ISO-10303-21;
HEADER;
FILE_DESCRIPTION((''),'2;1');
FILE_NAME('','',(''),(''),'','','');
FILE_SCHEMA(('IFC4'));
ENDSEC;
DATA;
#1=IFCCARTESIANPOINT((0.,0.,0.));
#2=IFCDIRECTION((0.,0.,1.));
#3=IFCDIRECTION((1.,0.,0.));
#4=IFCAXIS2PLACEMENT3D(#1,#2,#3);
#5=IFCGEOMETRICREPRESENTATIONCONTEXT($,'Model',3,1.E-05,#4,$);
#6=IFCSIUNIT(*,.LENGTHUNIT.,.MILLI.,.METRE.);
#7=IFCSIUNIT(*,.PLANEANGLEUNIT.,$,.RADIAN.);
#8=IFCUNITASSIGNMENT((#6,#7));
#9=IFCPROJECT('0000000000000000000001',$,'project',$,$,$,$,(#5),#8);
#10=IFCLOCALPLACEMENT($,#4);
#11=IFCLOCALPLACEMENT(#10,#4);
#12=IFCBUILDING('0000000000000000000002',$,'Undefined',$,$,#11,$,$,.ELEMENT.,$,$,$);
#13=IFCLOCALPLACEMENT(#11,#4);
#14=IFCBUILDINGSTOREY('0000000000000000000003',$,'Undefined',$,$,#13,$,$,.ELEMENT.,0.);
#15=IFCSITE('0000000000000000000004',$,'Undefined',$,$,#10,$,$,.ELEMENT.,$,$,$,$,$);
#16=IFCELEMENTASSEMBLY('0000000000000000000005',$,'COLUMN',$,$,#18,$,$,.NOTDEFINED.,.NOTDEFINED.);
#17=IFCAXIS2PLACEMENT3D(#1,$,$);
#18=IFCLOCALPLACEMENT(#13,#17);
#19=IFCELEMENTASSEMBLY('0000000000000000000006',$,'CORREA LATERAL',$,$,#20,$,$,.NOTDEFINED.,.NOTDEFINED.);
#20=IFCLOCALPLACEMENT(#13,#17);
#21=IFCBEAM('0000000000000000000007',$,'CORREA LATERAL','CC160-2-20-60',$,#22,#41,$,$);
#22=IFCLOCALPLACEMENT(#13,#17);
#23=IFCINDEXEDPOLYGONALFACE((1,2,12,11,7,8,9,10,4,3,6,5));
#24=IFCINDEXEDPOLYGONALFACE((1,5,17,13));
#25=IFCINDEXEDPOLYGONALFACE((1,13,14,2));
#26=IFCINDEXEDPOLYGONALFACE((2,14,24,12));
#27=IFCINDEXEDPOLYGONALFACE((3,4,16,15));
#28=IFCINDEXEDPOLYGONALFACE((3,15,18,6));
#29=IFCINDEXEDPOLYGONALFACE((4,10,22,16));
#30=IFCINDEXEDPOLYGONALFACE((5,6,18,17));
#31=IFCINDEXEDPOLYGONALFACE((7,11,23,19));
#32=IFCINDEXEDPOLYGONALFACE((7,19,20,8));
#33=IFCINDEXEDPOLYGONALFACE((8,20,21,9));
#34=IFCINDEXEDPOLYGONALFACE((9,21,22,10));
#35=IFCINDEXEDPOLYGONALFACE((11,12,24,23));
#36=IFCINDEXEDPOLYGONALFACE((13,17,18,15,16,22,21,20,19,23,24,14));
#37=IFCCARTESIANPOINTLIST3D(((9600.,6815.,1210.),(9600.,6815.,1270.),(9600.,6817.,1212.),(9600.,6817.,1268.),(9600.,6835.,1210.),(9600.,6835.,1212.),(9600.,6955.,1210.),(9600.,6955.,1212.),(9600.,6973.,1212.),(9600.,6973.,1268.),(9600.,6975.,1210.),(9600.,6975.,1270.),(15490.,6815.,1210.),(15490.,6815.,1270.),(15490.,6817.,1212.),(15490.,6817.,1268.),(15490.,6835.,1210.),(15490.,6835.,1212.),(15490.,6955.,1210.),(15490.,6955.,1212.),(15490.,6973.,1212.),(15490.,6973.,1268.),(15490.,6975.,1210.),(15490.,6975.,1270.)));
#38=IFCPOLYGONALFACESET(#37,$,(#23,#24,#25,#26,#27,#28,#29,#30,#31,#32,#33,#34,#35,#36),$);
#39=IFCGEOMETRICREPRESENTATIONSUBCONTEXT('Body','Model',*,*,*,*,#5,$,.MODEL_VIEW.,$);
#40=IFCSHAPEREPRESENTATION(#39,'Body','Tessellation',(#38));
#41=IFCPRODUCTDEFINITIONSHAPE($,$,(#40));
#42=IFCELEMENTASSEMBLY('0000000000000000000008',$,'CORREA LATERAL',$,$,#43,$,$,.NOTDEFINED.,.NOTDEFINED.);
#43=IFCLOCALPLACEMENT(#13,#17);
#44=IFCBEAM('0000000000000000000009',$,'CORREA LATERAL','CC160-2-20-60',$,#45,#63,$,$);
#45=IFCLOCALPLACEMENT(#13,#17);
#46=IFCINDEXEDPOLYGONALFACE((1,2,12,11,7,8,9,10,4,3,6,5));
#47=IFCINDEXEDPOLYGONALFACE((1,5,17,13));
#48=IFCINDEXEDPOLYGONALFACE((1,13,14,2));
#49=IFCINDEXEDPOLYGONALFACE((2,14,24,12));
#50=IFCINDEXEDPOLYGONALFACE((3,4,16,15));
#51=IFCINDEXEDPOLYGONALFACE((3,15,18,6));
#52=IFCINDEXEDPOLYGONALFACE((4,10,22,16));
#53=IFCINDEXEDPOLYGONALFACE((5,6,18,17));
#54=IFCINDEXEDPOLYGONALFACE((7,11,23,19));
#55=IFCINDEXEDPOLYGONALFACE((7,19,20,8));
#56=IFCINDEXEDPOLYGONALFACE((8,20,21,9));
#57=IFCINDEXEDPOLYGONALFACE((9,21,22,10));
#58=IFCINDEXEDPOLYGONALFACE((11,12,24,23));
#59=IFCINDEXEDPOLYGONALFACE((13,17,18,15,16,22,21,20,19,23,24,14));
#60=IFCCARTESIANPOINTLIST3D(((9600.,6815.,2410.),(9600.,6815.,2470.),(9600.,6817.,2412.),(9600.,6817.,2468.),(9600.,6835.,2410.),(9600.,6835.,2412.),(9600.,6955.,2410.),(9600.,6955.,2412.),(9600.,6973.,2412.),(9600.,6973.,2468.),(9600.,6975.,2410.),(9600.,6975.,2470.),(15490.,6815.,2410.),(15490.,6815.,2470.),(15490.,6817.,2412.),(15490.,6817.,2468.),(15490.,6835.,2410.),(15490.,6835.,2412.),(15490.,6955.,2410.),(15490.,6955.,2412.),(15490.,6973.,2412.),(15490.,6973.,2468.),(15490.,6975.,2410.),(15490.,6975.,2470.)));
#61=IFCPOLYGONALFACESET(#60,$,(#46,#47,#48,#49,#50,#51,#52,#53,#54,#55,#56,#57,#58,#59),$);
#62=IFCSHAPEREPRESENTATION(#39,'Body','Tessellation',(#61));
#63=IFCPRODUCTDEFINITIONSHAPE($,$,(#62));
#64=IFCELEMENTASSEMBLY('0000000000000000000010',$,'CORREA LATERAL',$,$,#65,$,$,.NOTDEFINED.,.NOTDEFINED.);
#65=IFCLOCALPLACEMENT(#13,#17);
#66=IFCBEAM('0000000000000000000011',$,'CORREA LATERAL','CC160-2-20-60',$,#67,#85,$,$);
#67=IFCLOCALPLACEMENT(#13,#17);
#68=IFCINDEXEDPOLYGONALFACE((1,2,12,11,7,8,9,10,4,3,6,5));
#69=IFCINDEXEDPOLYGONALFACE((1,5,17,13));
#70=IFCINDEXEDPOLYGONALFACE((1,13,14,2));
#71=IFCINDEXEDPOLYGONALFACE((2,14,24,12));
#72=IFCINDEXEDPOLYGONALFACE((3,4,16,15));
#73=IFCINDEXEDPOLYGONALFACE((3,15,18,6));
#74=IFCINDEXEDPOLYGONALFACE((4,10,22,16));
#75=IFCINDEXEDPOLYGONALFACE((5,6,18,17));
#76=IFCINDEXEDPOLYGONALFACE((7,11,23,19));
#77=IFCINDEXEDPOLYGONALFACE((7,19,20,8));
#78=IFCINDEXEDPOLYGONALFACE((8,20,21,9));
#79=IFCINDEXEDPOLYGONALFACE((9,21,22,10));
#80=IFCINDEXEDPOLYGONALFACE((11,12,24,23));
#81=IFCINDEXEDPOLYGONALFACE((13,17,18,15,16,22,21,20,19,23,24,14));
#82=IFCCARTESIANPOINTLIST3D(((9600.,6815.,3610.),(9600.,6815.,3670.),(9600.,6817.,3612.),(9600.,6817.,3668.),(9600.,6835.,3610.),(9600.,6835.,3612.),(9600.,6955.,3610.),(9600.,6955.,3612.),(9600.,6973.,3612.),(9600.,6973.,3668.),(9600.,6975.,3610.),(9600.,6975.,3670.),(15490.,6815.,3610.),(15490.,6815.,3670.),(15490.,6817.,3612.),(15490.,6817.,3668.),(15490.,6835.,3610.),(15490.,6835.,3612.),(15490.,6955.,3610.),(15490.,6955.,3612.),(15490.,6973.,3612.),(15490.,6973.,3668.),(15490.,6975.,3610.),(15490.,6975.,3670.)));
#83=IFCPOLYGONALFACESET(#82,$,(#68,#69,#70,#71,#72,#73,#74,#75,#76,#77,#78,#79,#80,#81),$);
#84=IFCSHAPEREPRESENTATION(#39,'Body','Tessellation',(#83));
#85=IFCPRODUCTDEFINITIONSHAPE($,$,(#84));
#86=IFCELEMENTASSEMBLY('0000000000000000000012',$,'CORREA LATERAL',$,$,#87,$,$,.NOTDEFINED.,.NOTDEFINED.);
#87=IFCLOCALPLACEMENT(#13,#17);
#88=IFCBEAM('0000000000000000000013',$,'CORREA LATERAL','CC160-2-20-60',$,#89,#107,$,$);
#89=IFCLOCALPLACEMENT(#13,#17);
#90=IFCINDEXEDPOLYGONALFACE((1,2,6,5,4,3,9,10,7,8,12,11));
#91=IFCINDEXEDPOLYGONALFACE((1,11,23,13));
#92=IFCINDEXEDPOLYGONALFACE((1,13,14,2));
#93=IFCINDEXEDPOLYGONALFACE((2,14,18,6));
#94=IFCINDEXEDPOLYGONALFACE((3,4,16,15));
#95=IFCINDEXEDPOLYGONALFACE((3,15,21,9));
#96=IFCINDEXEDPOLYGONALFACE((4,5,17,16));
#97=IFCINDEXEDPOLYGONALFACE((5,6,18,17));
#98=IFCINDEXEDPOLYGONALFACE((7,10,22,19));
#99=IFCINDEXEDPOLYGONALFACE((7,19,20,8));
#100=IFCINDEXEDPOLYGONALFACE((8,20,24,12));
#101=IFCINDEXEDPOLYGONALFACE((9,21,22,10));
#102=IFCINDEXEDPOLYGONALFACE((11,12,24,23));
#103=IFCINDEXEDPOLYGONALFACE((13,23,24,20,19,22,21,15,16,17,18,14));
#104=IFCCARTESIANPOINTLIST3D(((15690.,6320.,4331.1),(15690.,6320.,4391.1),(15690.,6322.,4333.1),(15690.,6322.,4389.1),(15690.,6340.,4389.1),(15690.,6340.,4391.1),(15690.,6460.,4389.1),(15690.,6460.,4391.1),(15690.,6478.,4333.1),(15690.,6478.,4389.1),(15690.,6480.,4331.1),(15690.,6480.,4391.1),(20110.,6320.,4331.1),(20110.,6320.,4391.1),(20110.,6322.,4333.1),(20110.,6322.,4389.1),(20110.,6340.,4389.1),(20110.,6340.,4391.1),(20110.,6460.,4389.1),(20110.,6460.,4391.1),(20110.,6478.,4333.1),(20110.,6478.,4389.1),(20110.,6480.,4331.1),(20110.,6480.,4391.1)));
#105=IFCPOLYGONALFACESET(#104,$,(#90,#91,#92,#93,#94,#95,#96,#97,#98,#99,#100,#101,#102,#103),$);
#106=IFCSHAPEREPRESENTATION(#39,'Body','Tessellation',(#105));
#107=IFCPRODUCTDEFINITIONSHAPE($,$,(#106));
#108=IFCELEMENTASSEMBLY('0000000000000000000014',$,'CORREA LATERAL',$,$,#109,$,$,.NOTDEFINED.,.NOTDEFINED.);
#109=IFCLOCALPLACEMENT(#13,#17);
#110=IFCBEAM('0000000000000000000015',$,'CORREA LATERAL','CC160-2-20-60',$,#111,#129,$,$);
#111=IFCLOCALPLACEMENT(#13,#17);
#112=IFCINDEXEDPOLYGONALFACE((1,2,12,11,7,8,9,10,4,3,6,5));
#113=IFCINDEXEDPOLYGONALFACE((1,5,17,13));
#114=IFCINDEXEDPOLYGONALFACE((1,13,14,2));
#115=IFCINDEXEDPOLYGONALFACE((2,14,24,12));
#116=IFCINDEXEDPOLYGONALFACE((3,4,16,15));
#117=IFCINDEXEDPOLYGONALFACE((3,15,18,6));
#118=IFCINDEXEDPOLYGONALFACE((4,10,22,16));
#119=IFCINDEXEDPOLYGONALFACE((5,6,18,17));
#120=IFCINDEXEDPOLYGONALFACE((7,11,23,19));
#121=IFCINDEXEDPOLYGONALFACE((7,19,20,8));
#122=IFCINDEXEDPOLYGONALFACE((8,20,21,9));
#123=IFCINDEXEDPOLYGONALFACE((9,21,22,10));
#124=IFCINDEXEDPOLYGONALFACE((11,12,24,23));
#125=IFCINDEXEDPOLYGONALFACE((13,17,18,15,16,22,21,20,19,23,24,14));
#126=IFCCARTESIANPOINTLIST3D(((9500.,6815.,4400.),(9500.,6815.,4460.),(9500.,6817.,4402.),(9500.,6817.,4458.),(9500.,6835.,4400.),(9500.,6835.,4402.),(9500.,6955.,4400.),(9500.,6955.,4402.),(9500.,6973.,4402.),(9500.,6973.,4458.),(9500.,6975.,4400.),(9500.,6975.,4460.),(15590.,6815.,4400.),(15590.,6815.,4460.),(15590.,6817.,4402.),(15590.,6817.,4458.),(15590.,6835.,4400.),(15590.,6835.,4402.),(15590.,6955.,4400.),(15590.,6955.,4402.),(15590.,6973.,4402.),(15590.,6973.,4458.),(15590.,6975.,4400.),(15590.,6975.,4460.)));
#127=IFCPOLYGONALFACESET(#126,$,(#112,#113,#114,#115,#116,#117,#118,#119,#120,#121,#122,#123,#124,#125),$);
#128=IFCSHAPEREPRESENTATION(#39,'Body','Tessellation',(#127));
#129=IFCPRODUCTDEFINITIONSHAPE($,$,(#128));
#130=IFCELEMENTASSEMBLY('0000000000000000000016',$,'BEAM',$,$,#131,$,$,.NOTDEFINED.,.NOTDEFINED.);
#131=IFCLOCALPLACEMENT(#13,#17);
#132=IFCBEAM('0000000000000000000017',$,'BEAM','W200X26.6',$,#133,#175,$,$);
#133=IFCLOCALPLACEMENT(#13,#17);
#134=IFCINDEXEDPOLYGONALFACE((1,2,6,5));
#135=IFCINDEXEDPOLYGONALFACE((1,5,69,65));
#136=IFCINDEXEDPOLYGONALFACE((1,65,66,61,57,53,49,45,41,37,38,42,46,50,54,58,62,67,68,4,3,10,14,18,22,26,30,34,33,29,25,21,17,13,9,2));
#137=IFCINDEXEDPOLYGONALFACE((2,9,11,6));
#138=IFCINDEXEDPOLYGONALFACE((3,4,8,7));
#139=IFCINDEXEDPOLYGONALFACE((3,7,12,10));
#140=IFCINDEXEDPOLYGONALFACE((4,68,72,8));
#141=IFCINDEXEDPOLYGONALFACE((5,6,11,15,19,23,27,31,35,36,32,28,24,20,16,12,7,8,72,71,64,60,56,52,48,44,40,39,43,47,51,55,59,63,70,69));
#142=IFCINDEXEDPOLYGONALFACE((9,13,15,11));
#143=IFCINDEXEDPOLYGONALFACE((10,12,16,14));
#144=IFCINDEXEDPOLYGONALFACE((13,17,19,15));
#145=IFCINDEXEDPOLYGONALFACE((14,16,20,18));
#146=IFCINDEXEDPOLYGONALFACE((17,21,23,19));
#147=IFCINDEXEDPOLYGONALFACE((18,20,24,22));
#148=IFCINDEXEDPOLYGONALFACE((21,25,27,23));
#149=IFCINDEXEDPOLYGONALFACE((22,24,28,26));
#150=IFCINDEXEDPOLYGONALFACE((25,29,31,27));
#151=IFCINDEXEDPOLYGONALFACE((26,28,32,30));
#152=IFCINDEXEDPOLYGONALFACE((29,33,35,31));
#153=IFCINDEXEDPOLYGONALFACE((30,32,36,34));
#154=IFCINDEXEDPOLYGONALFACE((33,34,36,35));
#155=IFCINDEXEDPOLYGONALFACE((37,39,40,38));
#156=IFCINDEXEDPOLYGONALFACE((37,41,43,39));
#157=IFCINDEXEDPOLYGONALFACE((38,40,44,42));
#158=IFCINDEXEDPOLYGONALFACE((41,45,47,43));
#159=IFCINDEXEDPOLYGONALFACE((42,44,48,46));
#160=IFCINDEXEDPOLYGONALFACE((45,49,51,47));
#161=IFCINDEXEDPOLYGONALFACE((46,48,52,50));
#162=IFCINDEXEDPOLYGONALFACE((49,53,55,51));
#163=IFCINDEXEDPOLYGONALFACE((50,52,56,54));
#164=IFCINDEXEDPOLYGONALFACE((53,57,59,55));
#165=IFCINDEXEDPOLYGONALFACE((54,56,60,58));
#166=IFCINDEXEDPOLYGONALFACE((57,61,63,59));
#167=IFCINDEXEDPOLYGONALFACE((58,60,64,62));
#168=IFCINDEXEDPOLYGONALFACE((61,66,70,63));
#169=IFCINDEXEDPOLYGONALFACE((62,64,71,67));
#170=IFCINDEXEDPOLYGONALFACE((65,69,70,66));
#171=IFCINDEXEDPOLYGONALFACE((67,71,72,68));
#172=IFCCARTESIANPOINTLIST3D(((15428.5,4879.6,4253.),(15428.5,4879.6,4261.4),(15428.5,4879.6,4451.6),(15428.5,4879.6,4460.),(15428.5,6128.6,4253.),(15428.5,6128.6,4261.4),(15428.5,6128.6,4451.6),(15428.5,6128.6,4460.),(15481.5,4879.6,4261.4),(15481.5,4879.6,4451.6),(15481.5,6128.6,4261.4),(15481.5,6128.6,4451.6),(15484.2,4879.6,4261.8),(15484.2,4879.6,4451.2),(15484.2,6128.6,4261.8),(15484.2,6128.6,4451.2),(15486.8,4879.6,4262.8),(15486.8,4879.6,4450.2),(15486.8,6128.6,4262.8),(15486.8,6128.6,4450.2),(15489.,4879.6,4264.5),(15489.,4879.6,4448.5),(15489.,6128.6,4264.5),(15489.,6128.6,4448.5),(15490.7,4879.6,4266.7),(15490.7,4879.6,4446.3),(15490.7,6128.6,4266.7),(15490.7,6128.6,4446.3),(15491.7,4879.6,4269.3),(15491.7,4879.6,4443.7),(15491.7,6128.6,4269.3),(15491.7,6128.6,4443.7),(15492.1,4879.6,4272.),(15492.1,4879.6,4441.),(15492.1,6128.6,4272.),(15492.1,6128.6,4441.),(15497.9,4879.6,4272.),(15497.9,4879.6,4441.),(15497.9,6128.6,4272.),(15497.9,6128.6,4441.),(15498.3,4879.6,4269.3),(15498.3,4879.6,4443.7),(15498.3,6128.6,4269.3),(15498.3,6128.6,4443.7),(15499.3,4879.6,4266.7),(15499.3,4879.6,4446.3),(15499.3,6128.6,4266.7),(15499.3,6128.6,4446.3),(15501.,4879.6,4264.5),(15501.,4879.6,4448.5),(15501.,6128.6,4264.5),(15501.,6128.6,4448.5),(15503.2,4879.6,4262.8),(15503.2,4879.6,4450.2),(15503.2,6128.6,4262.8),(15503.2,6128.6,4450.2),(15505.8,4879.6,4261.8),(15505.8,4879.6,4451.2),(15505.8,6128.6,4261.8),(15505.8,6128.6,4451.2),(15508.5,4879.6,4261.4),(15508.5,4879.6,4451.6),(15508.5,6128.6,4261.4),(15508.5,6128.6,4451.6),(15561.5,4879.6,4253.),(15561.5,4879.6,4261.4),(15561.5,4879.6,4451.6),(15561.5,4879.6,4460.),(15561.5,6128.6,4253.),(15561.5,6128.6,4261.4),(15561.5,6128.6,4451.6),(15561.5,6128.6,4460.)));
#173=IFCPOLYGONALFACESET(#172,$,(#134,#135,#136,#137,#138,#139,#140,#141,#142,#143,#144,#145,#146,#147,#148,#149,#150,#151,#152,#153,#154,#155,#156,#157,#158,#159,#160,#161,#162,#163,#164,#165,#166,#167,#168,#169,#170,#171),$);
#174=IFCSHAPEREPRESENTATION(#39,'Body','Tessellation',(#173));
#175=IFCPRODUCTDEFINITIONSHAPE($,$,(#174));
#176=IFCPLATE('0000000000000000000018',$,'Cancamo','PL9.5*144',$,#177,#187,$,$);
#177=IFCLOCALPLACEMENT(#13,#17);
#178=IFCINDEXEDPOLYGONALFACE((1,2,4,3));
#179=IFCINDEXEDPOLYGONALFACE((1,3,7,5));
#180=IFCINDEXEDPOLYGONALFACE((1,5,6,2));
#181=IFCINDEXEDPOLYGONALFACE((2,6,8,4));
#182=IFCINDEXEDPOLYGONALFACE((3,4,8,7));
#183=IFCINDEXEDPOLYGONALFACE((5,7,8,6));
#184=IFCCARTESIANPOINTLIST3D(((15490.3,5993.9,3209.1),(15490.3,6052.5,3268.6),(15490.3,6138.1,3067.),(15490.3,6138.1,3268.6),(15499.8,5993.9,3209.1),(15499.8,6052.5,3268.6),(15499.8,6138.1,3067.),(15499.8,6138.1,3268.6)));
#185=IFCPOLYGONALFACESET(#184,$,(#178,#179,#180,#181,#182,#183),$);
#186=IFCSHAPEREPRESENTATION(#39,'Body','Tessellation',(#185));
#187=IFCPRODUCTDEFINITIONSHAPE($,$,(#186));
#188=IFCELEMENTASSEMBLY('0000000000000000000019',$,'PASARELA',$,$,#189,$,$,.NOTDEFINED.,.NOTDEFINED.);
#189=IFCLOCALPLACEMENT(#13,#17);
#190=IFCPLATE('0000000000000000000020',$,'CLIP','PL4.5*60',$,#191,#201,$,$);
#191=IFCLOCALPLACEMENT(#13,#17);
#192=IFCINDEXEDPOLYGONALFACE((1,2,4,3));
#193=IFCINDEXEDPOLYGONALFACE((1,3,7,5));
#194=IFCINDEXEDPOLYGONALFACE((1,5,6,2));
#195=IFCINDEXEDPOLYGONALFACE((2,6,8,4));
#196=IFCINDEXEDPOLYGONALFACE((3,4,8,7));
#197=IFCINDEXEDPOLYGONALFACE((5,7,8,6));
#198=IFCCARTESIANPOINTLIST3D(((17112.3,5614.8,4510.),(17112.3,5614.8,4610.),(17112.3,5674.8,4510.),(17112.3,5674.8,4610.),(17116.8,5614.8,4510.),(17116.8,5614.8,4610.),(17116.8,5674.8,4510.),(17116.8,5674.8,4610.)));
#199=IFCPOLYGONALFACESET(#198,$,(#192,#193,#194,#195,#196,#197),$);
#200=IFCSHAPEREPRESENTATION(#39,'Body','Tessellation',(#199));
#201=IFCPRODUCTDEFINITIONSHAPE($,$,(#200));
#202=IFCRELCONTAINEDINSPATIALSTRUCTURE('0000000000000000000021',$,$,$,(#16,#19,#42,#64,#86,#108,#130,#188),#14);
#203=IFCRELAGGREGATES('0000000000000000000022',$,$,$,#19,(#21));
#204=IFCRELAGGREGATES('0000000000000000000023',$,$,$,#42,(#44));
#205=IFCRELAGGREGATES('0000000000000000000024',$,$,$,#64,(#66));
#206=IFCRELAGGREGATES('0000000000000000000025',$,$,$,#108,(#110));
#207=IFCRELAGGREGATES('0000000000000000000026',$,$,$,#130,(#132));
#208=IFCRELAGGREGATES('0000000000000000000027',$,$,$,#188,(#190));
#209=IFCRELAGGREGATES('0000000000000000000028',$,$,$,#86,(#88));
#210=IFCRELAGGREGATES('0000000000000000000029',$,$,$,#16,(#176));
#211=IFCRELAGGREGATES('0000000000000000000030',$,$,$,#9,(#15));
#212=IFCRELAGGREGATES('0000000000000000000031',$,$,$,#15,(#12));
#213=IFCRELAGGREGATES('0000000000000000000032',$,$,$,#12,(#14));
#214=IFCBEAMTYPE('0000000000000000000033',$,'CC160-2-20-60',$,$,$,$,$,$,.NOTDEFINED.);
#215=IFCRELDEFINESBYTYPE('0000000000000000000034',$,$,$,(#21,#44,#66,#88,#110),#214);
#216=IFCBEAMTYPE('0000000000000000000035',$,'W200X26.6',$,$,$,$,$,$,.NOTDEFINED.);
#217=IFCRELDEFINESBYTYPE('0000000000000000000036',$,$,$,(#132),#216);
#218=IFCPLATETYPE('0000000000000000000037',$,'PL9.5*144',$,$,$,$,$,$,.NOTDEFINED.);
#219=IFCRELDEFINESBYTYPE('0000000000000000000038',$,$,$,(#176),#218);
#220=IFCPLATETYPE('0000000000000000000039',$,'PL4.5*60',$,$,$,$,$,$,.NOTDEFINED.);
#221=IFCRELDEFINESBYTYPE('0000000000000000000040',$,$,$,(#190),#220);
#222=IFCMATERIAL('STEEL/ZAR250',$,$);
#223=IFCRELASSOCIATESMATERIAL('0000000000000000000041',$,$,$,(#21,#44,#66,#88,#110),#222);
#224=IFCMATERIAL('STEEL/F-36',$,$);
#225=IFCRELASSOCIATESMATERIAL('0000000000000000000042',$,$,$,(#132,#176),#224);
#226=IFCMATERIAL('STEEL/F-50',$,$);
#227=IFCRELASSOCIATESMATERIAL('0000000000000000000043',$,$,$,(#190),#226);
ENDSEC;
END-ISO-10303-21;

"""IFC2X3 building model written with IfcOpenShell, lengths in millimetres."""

from ifc_helpers import new_model, si_unit, frame, origin_with_axes, origin_2d_with_axis, place, context, subcontext, project, spatial, polyline, i_section, c_section, outline, extrude, clip, halfspace, material, type_object, element, aggregate, save


model = new_model("IFC2X3")

# Units and contexts
model_context = context("Model", 3, precision=1e-05, world=origin_with_axes())
body_context = subcontext(model_context, "Body", "Model", "MODEL_VIEW")
ifc_project = project(units=[si_unit("LENGTHUNIT", "METRE", prefix="MILLI"), si_unit("PLANEANGLEUNIT", "RADIAN")], contexts=[model_context])

# Site, building, storey
site_placement = place(None, origin_with_axes())
site = spatial("IfcSite", under=ifc_project, at=site_placement, Name="Undefined", CompositionType="ELEMENT")
building_placement = place(site_placement, origin_with_axes())
building = spatial("IfcBuilding", under=site, at=building_placement, Name="Undefined", CompositionType="ELEMENT")
storey_placement = place(building_placement, origin_with_axes())
storey = spatial("IfcBuildingStorey", under=building, at=storey_placement, Name="Undefined", CompositionType="ELEMENT", Elevation=0.0)

# Element assembly
assembly_1_placement = place(storey_placement, origin_with_axes())
assembly_1 = element("IfcElementAssembly", 1, at=assembly_1_placement, inside=storey, Name="COLUMN", AssemblyPlace="NOTDEFINED", PredefinedType="NOTDEFINED")
ifc_material_1 = material(Name="STEEL/F-36")

# Element assemblies, beams
assembly_2_placement = place(storey_placement, origin_with_axes())
assembly_2 = element("IfcElementAssembly", 2, at=assembly_2_placement, inside=storey, Name="CORREA LATERAL", AssemblyPlace="NOTDEFINED", PredefinedType="NOTDEFINED")
ifc_material_2 = material(Name="STEEL/ZAR250")
beam_type_1 = type_object("IfcBeamType", Name="CC160-2-20-60", PredefinedType="NOTDEFINED")
beam_1_placement = place(assembly_2_placement, frame((15490.0, 6895.0, 1240.0), z_axis=(0.0, 1.0, 0.0), x_axis=(-1.0, 0.0, 0.0)))
beam_1 = element("IfcBeam", 3, at=beam_1_placement, type_object=beam_type_1, material=ifc_material_2, Name="CORREA LATERAL", Description="CC160-2-20-60", context=body_context, shape_type="SweptSolid", body=[
    extrude(c_section(Depth=160.0, Width=60.0, WallThickness=2.0, Girth=20.0, at=origin_2d_with_axis()), frame((5890.0, 0.0, 0.0), z_axis=(-1.0, 0.0, 0.0), x_axis=(0.0, -1.0, 0.0)), (0.0, 0.0, 1.0), 5890.0),
])
aggregate(assembly_2, [beam_1])
assembly_3_placement = place(storey_placement, origin_with_axes())
assembly_3 = element("IfcElementAssembly", 4, at=assembly_3_placement, inside=storey, Name="CORREA LATERAL", AssemblyPlace="NOTDEFINED", PredefinedType="NOTDEFINED")
beam_2_placement = place(assembly_3_placement, frame((15490.0, 6895.0, 2440.0), z_axis=(0.0, 1.0, 0.0), x_axis=(-1.0, 0.0, 0.0)))
beam_2 = element("IfcBeam", 5, at=beam_2_placement, type_object=beam_type_1, material=ifc_material_2, Name="CORREA LATERAL", Description="CC160-2-20-60", context=body_context, shape_type="SweptSolid", body=[
    extrude(c_section(Depth=160.0, Width=60.0, WallThickness=2.0, Girth=20.0, at=origin_2d_with_axis()), frame((5890.0, 0.0, 0.0), z_axis=(-1.0, 0.0, 0.0), x_axis=(0.0, -1.0, 0.0)), (0.0, 0.0, 1.0), 5890.0),
])
aggregate(assembly_3, [beam_2])
assembly_4_placement = place(storey_placement, origin_with_axes())
assembly_4 = element("IfcElementAssembly", 6, at=assembly_4_placement, inside=storey, Name="CORREA LATERAL", AssemblyPlace="NOTDEFINED", PredefinedType="NOTDEFINED")
beam_3_placement = place(assembly_4_placement, frame((15490.0, 6895.0, 3640.0), z_axis=(0.0, 1.0, 0.0), x_axis=(-1.0, 0.0, 0.0)))
beam_3 = element("IfcBeam", 7, at=beam_3_placement, type_object=beam_type_1, material=ifc_material_2, Name="CORREA LATERAL", Description="CC160-2-20-60", context=body_context, shape_type="SweptSolid", body=[
    extrude(c_section(Depth=160.0, Width=60.0, WallThickness=2.0, Girth=20.0, at=origin_2d_with_axis()), frame((5890.0, 0.0, 0.0), z_axis=(-1.0, 0.0, 0.0), x_axis=(0.0, -1.0, 0.0)), (0.0, 0.0, 1.0), 5890.0),
])
aggregate(assembly_4, [beam_3])
assembly_5_placement = place(storey_placement, origin_with_axes())
assembly_5 = element("IfcElementAssembly", 8, at=assembly_5_placement, inside=storey, Name="CORREA LATERAL", AssemblyPlace="NOTDEFINED", PredefinedType="NOTDEFINED")
beam_4_placement = place(assembly_5_placement, frame((15690.0, 6400.0, 4361.1), z_axis=(0.0, 1.0, 0.0), x_axis=(1.0, 0.0, 0.0)))
beam_4 = element("IfcBeam", 9, at=beam_4_placement, type_object=beam_type_1, material=ifc_material_2, Name="CORREA LATERAL", Description="CC160-2-20-60", context=body_context, shape_type="SweptSolid", body=[
    extrude(c_section(Depth=160.0, Width=60.0, WallThickness=2.0, Girth=20.0, at=origin_2d_with_axis()), frame((4420.0, 0.0, 0.0), z_axis=(-1.0, 0.0, 0.0), x_axis=(0.0, -1.0, 0.0)), (0.0, 0.0, 1.0), 4420.0),
])
assembly_6_placement = place(storey_placement, origin_with_axes())
assembly_6 = element("IfcElementAssembly", 10, at=assembly_6_placement, inside=storey, Name="CORREA LATERAL", AssemblyPlace="NOTDEFINED", PredefinedType="NOTDEFINED")
beam_5_placement = place(assembly_6_placement, frame((15590.0, 6895.0, 4430.0), z_axis=(0.0, 1.0, 0.0), x_axis=(-1.0, 0.0, 0.0)))
beam_5 = element("IfcBeam", 11, at=beam_5_placement, type_object=beam_type_1, material=ifc_material_2, Name="CORREA LATERAL", Description="CC160-2-20-60", context=body_context, shape_type="SweptSolid", body=[
    extrude(c_section(Depth=160.0, Width=60.0, WallThickness=2.0, Girth=20.0, at=origin_2d_with_axis()), frame((6090.0, 0.0, 0.0), z_axis=(-1.0, 0.0, 0.0), x_axis=(0.0, -1.0, 0.0)), (0.0, 0.0, 1.0), 6090.0),
])
aggregate(assembly_6, [beam_5])
assembly_7_placement = place(storey_placement, origin_with_axes())
assembly_7 = element("IfcElementAssembly", 12, at=assembly_7_placement, inside=storey, Name="BEAM", AssemblyPlace="NOTDEFINED", PredefinedType="NOTDEFINED")
beam_type_2 = type_object("IfcBeamType", Name="W200X26.6", PredefinedType="NOTDEFINED")
beam_6_placement = place(assembly_7_placement, frame((15495.0, 6138.1, 4356.5), z_axis=(0.0, 0.0, 1.0), x_axis=(0.0, -1.0, 0.0)))
beam_6 = element("IfcBeam", 13, at=beam_6_placement, type_object=beam_type_2, material=ifc_material_1, Name="BEAM", Description="W200X26.6", context=body_context, shape_type="Clipping", body=[
    clip(extrude(i_section(OverallWidth=133.0, OverallDepth=207.0, WebThickness=5.8, FlangeThickness=8.4, FilletRadius=10.6, at=origin_2d_with_axis()), frame((1258.5, 0.0, 0.0), z_axis=(-1.0, 0.0, 0.0), x_axis=(0.0, -1.0, 0.0)), (0.0, 0.0, 1.0), 1258.5), halfspace(frame((9.5, 0.0, -103.5), z_axis=(1.0, 0.0, 0.0), x_axis=(0.0, -1.0, 0.0)), True)),
])

# Plate
plate_type_1 = type_object("IfcPlateType", Name="PL9.5*144", PredefinedType="NOTDEFINED")
plate_1_placement = place(assembly_1_placement, frame((15495.0, 6138.1, 3268.6), z_axis=(-1.0, 0.0, 0.0), x_axis=(0.0, 0.0, -1.0)))
plate_1 = element("IfcPlate", 14, at=plate_1_placement, type_object=plate_type_1, material=ifc_material_1, Name="Cancamo", Description="PL9.5*144", context=body_context, shape_type="SweptSolid", body=[
    extrude(outline(polyline([(0.0, 0.0), (201.6, 0.0), (59.5, 144.2), (0.0, 85.6), (0.0, 0.0)])), frame((0.0, 0.0, -4.8), z_axis=(0.0, 0.0, 1.0), x_axis=(1.0, 0.0, 0.0)), (0.0, 0.0, 1.0), 9.5),
])

# Element assembly, plate
assembly_8_placement = place(storey_placement, origin_with_axes())
assembly_8 = element("IfcElementAssembly", 15, at=assembly_8_placement, inside=storey, Name="PASARELA", AssemblyPlace="NOTDEFINED", PredefinedType="NOTDEFINED")
ifc_material_3 = material(Name="STEEL/F-50")
plate_type_2 = type_object("IfcPlateType", Name="PL4.5*60", PredefinedType="NOTDEFINED")
plate_2_placement = place(assembly_8_placement, frame((17114.5, 5674.8, 4510.0), z_axis=(-1.0, 0.0, 0.0), x_axis=(0.000001, -1.0, 0.000014)))
plate_2 = element("IfcPlate", 16, at=plate_2_placement, type_object=plate_type_2, material=ifc_material_3, Name="CLIP", Description="PL4.5*60", context=body_context, shape_type="SweptSolid", body=[
    extrude(outline(polyline([(0.0, 0.0), (60.0, 0.0), (60.0, 100.0), (0.0, 100.0), (0.0, 0.0)])), frame((0.0, 0.0, -2.2), z_axis=(0.0, 0.0, 1.0), x_axis=(1.0, 0.0, 0.0)), (0.0, 0.0, 1.0), 4.5),
])

aggregate(assembly_7, [beam_6])

aggregate(assembly_8, [plate_2])
aggregate(assembly_5, [beam_4])

aggregate(assembly_1, [plate_1])

save(model, "model.ifc")
